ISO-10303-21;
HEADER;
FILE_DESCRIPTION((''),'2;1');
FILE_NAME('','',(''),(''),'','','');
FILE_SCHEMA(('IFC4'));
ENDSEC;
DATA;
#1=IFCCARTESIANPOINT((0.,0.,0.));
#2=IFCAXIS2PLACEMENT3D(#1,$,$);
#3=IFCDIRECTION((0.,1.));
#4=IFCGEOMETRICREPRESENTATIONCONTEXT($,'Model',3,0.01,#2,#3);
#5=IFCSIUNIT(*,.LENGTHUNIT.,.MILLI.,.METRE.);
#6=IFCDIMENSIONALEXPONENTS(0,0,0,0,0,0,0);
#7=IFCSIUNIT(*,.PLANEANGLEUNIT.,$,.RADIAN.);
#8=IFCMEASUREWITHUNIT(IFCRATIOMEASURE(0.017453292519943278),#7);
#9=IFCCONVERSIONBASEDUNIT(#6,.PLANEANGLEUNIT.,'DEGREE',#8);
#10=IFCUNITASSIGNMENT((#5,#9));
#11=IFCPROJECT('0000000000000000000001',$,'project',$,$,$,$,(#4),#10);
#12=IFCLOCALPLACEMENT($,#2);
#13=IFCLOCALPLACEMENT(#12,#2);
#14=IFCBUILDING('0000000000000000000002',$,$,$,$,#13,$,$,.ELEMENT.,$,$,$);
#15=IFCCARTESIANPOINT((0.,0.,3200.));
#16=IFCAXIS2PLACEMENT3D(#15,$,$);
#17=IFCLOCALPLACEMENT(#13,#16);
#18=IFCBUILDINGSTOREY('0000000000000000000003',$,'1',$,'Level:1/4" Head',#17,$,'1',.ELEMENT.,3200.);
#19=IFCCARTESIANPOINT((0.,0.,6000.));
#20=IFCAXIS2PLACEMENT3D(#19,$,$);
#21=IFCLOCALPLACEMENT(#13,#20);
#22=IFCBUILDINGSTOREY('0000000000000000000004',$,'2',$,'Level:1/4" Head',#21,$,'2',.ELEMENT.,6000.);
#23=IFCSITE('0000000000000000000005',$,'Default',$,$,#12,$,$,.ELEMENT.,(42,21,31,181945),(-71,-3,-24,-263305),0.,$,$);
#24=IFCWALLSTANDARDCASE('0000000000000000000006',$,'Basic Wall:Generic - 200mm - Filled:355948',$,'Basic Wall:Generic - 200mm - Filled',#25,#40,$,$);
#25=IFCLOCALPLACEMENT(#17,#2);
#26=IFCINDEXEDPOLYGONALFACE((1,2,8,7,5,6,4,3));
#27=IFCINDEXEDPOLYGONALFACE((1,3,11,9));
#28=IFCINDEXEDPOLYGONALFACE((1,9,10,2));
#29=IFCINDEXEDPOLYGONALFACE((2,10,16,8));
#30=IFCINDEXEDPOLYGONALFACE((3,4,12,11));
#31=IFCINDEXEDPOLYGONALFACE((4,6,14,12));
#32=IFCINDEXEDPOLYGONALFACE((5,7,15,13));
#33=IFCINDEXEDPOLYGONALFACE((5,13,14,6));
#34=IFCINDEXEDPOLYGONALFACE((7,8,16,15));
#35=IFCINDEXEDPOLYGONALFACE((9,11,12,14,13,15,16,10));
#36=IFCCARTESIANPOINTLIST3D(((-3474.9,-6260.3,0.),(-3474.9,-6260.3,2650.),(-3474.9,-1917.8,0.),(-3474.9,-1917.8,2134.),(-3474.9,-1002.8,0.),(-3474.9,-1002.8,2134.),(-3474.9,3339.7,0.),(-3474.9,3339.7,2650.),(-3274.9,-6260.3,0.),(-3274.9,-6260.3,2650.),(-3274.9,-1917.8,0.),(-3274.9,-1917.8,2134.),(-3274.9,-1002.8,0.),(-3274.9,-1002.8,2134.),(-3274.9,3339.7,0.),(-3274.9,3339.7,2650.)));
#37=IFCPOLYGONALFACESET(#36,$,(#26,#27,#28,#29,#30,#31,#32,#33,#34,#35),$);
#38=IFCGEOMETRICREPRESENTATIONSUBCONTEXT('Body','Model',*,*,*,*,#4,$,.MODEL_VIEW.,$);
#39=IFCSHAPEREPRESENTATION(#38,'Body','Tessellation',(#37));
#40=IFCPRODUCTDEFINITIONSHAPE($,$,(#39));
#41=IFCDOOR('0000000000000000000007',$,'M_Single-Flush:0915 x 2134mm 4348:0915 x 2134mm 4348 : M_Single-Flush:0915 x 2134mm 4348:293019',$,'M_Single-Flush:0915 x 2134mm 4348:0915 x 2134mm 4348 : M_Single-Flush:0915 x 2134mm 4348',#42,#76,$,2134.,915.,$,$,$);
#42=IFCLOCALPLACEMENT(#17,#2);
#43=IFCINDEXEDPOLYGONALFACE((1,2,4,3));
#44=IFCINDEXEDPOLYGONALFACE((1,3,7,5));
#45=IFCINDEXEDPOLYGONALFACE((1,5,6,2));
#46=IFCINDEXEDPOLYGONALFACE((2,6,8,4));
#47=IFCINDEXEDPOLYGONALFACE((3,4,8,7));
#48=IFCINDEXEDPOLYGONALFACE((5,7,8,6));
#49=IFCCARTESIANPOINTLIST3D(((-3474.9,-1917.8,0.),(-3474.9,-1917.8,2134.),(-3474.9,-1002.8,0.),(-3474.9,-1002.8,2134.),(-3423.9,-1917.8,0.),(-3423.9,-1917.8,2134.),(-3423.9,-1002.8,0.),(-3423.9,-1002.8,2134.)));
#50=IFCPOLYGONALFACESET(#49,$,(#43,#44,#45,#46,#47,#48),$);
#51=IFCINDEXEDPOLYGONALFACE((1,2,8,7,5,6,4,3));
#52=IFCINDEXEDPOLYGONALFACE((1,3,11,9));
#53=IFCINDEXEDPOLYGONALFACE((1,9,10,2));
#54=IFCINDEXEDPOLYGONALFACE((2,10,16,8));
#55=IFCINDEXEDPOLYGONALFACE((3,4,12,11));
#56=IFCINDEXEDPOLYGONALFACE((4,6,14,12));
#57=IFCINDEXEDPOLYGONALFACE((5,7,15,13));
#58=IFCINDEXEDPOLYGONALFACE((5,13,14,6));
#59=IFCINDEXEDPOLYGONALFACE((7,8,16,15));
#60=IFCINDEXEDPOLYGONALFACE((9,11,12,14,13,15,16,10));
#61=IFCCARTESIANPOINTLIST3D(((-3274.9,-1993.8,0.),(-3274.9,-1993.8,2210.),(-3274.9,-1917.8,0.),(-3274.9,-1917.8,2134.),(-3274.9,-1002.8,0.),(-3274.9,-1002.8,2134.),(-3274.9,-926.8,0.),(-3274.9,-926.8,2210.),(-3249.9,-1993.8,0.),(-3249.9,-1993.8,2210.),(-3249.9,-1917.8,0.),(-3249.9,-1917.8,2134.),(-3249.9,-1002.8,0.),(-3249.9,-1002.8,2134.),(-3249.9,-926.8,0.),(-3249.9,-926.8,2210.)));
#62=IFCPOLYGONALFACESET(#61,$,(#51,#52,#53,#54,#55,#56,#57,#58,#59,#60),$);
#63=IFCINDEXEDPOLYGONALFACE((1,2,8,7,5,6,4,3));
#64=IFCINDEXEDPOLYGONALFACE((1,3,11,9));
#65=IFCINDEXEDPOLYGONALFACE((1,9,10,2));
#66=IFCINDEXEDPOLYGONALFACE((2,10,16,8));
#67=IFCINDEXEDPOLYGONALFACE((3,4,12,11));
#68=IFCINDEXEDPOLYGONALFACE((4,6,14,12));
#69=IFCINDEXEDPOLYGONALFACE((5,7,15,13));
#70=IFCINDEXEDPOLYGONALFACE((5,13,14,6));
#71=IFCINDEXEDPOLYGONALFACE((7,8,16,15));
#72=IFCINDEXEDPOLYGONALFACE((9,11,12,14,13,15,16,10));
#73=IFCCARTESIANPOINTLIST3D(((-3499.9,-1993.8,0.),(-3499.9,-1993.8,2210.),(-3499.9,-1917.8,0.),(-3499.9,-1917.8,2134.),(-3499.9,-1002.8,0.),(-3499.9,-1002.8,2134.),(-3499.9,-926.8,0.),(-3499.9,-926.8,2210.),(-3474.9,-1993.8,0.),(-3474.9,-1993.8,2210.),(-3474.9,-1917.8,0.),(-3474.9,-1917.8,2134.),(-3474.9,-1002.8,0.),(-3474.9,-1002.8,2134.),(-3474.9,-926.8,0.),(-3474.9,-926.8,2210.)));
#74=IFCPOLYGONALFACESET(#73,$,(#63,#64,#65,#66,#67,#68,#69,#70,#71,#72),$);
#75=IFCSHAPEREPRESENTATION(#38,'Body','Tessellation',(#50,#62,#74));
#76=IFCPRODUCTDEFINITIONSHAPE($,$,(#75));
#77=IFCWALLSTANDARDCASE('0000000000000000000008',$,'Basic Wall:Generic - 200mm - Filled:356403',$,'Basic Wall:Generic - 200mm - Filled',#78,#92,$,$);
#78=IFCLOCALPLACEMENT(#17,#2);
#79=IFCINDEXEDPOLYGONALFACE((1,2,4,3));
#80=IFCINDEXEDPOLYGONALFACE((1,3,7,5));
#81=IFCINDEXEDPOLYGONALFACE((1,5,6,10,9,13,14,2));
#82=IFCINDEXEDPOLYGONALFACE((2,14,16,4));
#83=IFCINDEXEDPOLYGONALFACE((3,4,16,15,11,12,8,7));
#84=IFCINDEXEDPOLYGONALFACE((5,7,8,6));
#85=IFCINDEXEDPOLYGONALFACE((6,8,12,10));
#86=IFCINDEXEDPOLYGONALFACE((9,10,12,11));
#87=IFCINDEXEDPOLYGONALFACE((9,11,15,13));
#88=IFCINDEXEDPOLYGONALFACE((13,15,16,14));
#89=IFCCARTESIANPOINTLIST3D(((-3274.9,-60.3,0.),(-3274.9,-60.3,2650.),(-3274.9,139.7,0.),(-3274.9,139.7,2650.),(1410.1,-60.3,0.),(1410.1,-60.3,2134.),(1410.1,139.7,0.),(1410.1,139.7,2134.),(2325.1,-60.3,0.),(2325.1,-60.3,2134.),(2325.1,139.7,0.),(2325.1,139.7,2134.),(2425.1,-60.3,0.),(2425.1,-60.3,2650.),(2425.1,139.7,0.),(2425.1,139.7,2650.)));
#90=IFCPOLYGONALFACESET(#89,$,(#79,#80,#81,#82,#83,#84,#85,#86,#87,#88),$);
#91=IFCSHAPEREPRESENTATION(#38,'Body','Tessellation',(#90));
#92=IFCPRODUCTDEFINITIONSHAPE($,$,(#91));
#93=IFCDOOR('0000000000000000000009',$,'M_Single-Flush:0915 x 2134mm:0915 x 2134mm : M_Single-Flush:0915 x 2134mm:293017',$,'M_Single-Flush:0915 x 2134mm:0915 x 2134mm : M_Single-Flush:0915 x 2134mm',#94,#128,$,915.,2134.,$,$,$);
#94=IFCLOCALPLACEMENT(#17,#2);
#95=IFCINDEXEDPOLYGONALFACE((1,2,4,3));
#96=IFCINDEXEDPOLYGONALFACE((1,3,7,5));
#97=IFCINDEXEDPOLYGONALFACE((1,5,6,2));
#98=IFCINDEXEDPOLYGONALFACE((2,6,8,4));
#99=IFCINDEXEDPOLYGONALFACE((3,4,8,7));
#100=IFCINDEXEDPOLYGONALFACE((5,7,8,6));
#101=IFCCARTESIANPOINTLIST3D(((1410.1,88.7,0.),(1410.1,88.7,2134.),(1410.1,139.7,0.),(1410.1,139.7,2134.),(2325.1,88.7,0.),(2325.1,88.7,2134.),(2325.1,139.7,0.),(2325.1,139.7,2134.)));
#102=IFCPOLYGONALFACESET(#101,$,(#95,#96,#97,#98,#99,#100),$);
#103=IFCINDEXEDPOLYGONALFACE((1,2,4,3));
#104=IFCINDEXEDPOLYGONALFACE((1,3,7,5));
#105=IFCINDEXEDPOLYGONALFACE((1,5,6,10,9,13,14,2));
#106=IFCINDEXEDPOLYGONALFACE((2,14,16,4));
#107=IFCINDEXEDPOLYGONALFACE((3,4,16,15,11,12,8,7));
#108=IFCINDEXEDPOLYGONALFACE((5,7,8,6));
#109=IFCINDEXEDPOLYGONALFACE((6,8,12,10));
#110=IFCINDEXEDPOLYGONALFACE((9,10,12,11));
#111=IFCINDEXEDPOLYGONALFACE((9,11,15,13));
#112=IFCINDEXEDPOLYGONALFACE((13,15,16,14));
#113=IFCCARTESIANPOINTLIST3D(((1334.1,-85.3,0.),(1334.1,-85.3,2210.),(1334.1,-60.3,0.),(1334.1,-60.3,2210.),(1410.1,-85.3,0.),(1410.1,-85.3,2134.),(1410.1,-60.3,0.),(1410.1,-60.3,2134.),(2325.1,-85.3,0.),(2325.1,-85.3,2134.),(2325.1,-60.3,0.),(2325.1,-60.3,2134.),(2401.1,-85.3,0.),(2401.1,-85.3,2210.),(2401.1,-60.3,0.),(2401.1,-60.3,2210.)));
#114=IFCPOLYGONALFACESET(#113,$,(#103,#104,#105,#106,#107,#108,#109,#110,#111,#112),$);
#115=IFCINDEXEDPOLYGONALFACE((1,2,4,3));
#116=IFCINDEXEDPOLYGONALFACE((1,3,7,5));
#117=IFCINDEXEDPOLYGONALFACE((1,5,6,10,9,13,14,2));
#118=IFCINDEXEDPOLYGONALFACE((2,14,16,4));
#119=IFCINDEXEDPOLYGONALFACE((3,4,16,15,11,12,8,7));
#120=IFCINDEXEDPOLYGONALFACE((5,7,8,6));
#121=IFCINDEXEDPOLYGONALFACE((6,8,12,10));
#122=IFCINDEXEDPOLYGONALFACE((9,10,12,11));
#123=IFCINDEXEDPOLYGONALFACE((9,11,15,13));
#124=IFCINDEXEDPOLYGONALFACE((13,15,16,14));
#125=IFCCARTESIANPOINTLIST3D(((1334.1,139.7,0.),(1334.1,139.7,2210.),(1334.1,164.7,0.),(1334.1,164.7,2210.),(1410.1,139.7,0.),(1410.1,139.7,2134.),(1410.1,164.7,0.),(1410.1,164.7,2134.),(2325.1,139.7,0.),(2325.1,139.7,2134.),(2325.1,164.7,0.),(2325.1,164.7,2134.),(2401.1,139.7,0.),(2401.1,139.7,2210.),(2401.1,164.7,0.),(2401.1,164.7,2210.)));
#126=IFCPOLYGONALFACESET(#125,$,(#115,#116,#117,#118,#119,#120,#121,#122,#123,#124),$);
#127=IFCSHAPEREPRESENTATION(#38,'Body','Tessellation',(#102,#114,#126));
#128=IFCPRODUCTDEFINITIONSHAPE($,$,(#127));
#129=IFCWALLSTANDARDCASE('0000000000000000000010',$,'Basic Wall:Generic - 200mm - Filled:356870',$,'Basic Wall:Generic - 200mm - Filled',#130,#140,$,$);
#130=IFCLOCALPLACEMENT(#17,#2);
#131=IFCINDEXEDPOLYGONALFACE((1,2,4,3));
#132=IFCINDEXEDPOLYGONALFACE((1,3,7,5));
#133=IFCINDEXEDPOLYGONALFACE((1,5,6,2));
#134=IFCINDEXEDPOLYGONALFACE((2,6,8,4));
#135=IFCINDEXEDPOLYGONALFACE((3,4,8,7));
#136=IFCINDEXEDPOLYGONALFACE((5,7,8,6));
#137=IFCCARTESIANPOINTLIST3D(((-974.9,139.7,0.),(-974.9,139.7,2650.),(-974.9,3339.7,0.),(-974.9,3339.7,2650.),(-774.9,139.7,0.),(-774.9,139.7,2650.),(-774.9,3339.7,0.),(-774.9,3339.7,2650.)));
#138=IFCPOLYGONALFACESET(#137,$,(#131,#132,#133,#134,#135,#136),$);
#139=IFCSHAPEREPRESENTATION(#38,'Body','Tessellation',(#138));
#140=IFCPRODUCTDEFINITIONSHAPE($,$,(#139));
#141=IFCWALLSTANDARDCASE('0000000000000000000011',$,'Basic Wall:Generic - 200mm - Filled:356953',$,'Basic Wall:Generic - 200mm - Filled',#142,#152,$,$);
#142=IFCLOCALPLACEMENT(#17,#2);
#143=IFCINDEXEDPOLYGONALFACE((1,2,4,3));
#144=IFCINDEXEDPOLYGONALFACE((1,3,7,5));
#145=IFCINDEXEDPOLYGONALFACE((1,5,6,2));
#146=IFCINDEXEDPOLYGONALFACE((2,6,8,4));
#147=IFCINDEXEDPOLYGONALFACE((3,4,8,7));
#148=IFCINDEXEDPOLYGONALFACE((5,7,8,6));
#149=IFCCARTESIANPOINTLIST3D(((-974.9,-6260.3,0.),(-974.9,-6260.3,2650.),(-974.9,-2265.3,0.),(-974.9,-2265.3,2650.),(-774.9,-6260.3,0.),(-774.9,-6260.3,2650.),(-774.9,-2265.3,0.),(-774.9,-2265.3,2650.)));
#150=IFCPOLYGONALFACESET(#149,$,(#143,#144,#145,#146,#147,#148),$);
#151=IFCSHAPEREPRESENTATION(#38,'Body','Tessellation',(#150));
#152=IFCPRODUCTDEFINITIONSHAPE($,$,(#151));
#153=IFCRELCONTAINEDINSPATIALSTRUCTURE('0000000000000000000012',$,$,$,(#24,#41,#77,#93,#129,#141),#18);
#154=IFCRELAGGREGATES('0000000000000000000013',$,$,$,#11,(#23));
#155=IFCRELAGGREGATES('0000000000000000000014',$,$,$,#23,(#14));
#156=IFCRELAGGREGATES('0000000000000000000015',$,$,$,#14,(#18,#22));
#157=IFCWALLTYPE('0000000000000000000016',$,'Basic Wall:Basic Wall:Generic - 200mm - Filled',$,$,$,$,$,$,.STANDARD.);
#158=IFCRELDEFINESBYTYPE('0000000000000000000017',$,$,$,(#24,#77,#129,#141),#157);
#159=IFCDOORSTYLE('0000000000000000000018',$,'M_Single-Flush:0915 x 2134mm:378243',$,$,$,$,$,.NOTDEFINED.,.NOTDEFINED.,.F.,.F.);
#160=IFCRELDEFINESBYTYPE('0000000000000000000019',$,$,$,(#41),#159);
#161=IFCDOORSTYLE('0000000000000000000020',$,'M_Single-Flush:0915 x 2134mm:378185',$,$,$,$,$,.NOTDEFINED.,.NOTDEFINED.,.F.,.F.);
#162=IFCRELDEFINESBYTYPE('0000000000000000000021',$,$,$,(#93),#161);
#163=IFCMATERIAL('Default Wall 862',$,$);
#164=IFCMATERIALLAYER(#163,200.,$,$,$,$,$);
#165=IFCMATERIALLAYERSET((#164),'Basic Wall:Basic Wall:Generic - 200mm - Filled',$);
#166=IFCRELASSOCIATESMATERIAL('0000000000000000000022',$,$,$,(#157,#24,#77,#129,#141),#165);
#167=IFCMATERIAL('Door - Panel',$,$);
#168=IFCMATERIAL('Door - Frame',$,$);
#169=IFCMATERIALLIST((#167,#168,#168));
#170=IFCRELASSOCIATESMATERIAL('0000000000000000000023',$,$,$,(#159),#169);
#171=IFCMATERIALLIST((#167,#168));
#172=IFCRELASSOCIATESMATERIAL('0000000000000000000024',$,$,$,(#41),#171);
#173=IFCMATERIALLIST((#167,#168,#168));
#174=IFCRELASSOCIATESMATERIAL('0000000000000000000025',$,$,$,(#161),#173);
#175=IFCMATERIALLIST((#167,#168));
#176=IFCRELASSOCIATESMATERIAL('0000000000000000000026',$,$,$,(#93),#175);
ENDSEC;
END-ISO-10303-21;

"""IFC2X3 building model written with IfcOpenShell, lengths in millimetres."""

from ifc_helpers import new_model, entity, si_unit, converted_unit, direction, frame, frame_2d, origin, origin_2d_with_axis, place, context, subcontext, project, spatial, polyline, rectangle, outline, extrude, source, transform, mapped, material, material_list, layer, layer_set, layer_usage, type_object, type_shapes, element, fill, save


model = new_model("IFC2X3")

# Units and contexts
model_context = context("Model", 3, precision=0.01, world=origin(), true_north=direction((0.0, 1.0)))
body_context = subcontext(model_context, "Body", "Model", "MODEL_VIEW")
ifc_project = project(units=[si_unit("LENGTHUNIT", "METRE", prefix="MILLI"), converted_unit("PLANEANGLEUNIT", "DEGREE", entity("IfcRatioMeasure", 0.017453292519943278), si_unit("PLANEANGLEUNIT", "RADIAN"), dimensions=[0, 0, 0, 0, 0, 0, 0])], contexts=[model_context])

# Site, building, storey
site_placement = place(None, origin())
site = spatial("IfcSite", under=ifc_project, at=site_placement, Name="Default", CompositionType="ELEMENT", RefLatitude=(42, 21, 31, 181945), RefLongitude=(-71, -3, -24, -263305), RefElevation=0.0)
building_placement = place(site_placement, origin())
building = spatial("IfcBuilding", under=site, at=building_placement, CompositionType="ELEMENT")
storey_1_placement = place(building_placement, frame((0.0, 0.0, 3200.0)))
storey_1 = spatial("IfcBuildingStorey", under=building, at=storey_1_placement, Name="1", ObjectType="Level:1/4\" Head", LongName="1", CompositionType="ELEMENT", Elevation=3200.0)

# Shared definitions
ifc_material_1 = material(Name="Default Wall 862")

# Shared definitions
storey_2_placement = place(building_placement, frame((0.0, 0.0, 6000.0)))
storey_2 = spatial("IfcBuildingStorey", under=building, at=storey_2_placement, Name="2", ObjectType="Level:1/4\" Head", LongName="2", CompositionType="ELEMENT", Elevation=6000.0)

# Walls, openings, doors
ifc_layer_1 = layer(ifc_material_1, 200.0)
ifc_layer_set_1 = layer_set([ifc_layer_1], Name="Basic Wall:Basic Wall:Generic - 200mm - Filled")
ifc_layer_usage_1 = layer_usage(ifc_layer_set_1, "AXIS2", "NEGATIVE", 100.0)
wall_type_1 = type_object("IfcWallType", Name="Basic Wall:Basic Wall:Generic - 200mm - Filled", PredefinedType="STANDARD", material=ifc_layer_set_1)
wall_1_placement = place(storey_1_placement, frame((-3374.9, 3339.7, 0.0), z_axis=(0.0, 0.0, 1.0), x_axis=(0.0, -1.0, 0.0)))
wall_1 = element("IfcWallStandardCase", 1, at=wall_1_placement, inside=storey_1, type_object=wall_type_1, material=ifc_layer_usage_1, Name="Basic Wall:Generic - 200mm - Filled:355948", ObjectType="Basic Wall:Generic - 200mm - Filled", context=body_context, shape_type="SweptSolid", body=[
    extrude(rectangle(XDim=9600.0, YDim=200.0, at=frame_2d((4800.0, 0.0), x_axis=(1.0, 0.0))), origin(), (0.0, 0.0, 1.0), 2650.0),
])
opening_1_placement = place(wall_1_placement, frame((3339.7, 3374.9, 0.0), z_axis=(0.0, 0.0, 1.0), x_axis=(0.0, 1.0, 0.0)))
opening_1 = element("IfcOpeningElement", 2, at=opening_1_placement, cuts=wall_1, ObjectType="Opening", context=body_context, shape_type="SweptSolid", body=[
    extrude(rectangle(XDim=2134.0, YDim=915.0, at=frame_2d((0.0, 0.0), x_axis=(0.0, 1.0))), frame((-3476.9, -1460.3, 1067.0), z_axis=(1.0, 0.0, 0.0), x_axis=(0.0, -1.0, 0.0)), (0.0, 0.0, 1.0), 204.0),
])
ifc_material_2 = material(Name="Door - Panel")
ifc_material_3 = material(Name="Door - Frame")
ifc_material_list_1 = material_list([ifc_material_2, ifc_material_3])
ifc_material_list_2 = material_list([ifc_material_2, ifc_material_3, ifc_material_3])
door_style_1 = type_object("IfcDoorStyle", Name="M_Single-Flush:0915 x 2134mm:378243", ConstructionType="NOTDEFINED", OperationType="NOTDEFINED", ParameterTakesPrecedence=False, Sizeable=False, material=ifc_material_list_2)
shared_shape_1 = source(origin(), body_context, "Body", "SweptSolid", [
    extrude(rectangle(XDim=915.0, YDim=51.0, at=origin_2d_with_axis()), frame((457.5, 176.5, 0.0), z_axis=(0.0, 0.0, 1.0), x_axis=(-1.0, 0.0, 0.0)), (0.0, 0.0, 1.0), 2134.0),
    extrude(outline(polyline([(-533.5, -1086.0), (-457.5, -1086.0), (-457.5, 1048.0), (457.5, 1048.0), (457.5, -1086.0), (533.5, -1086.0), (533.5, 1124.0), (-533.5, 1124.0), (-533.5, -1086.0)])), frame((457.5, -23.0, 1086.0), z_axis=(0.0, 1.0, 0.0), x_axis=(-1.0, 0.0, 0.0)), (0.0, 0.0, 1.0), 25.0),
    extrude(outline(polyline([(-1124.0, -533.5), (1086.0, -533.5), (1086.0, -457.5), (-1048.0, -457.5), (-1048.0, 457.5), (1086.0, 457.5), (1086.0, 533.5), (-1124.0, 533.5), (-1124.0, -533.5)])), frame((457.5, 202.0, 1086.0), z_axis=(0.0, 1.0, 0.0), x_axis=(0.0, 0.0, -1.0)), (0.0, 0.0, 1.0), 25.0),
])
type_shapes(door_style_1, [shared_shape_1])
door_1_placement = place(opening_1_placement, frame((-3272.9, -1917.8, 0.0), z_axis=(0.0, 0.0, 1.0), x_axis=(0.0, 1.0, 0.0)))
door_1 = element("IfcDoor", 3, at=door_1_placement, inside=storey_1, type_object=door_style_1, material=ifc_material_list_1, Name="M_Single-Flush:0915 x 2134mm 4348:0915 x 2134mm 4348 : M_Single-Flush:0915 x 2134mm 4348:293019", ObjectType="M_Single-Flush:0915 x 2134mm 4348:0915 x 2134mm 4348 : M_Single-Flush:0915 x 2134mm 4348", OverallHeight=2134.0, OverallWidth=915.0, context=body_context, shape_type="MappedRepresentation", body=[
    mapped(shared_shape_1, transform((0.0, 0.0, 0.0), scale=1.0)),
])
fill(opening_1, door_1)
ifc_layer_usage_2 = layer_usage(ifc_layer_set_1, "AXIS2", "NEGATIVE", 100.0)
wall_2_placement = place(storey_1_placement, frame((-3274.9, 39.7, 0.0)))
wall_2 = element("IfcWallStandardCase", 4, at=wall_2_placement, inside=storey_1, type_object=wall_type_1, material=ifc_layer_usage_2, Name="Basic Wall:Generic - 200mm - Filled:356403", ObjectType="Basic Wall:Generic - 200mm - Filled", context=body_context, shape_type="SweptSolid", body=[
    extrude(rectangle(XDim=5700.0, YDim=200.0, at=frame_2d((2850.0, 0.0), x_axis=(-1.0, 0.0))), origin(), (0.0, 0.0, 1.0), 2650.0),
])
opening_2_placement = place(wall_2_placement, frame((3274.9, -39.7, 0.0)))
opening_2 = element("IfcOpeningElement", 5, at=opening_2_placement, cuts=wall_2, ObjectType="Opening", context=body_context, shape_type="SweptSolid", body=[
    extrude(rectangle(XDim=2134.0, YDim=915.0, at=frame_2d((0.0, 0.0), x_axis=(1.0, 0.0))), frame((1867.6, -62.3, 1067.0), z_axis=(0.0, 1.0, 0.0), x_axis=(0.0, 0.0, 1.0)), (0.0, 0.0, 1.0), 204.0),
])
ifc_material_list_3 = material_list([ifc_material_2, ifc_material_3])
ifc_material_list_4 = material_list([ifc_material_2, ifc_material_3, ifc_material_3])
door_style_2 = type_object("IfcDoorStyle", Name="M_Single-Flush:0915 x 2134mm:378185", ConstructionType="NOTDEFINED", OperationType="NOTDEFINED", ParameterTakesPrecedence=False, Sizeable=False, material=ifc_material_list_4)
shared_shape_2 = source(origin(), body_context, "Body", "SweptSolid", [
    extrude(rectangle(XDim=51.0, YDim=915.0, at=origin_2d_with_axis()), frame((457.5, -27.5, 0.0), z_axis=(0.0, 0.0, 1.0), x_axis=(0.0, 1.0, 0.0)), (0.0, 0.0, 1.0), 2134.0),
    extrude(outline(polyline([(-1086.0, -533.5), (1124.0, -533.5), (1124.0, 533.5), (-1086.0, 533.5), (-1086.0, 457.5), (1048.0, 457.5), (1048.0, -457.5), (-1086.0, -457.5), (-1086.0, -533.5)])), frame((457.5, -227.0, 1086.0), z_axis=(0.0, 1.0, 0.0), x_axis=(0.0, 0.0, 1.0)), (0.0, 0.0, 1.0), 25.0),
    extrude(outline(polyline([(-533.5, -1124.0), (533.5, -1124.0), (533.5, 1086.0), (457.5, 1086.0), (457.5, -1048.0), (-457.5, -1048.0), (-457.5, 1086.0), (-533.5, 1086.0), (-533.5, -1124.0)])), frame((457.5, -2.0, 1086.0), z_axis=(0.0, 1.0, 0.0), x_axis=(1.0, 0.0, 0.0)), (0.0, 0.0, 1.0), 25.0),
])
type_shapes(door_style_2, [shared_shape_2])
door_2_placement = place(opening_2_placement, frame((1410.1, 141.7, 0.0)))
door_2 = element("IfcDoor", 6, at=door_2_placement, inside=storey_1, type_object=door_style_2, material=ifc_material_list_3, Name="M_Single-Flush:0915 x 2134mm:0915 x 2134mm : M_Single-Flush:0915 x 2134mm:293017", ObjectType="M_Single-Flush:0915 x 2134mm:0915 x 2134mm : M_Single-Flush:0915 x 2134mm", OverallHeight=915.0, OverallWidth=2134.0, context=body_context, shape_type="MappedRepresentation", body=[
    mapped(shared_shape_2, transform((0.0, 0.0, 0.0), scale=1.0)),
])
fill(opening_2, door_2)

# Walls
ifc_layer_usage_3 = layer_usage(ifc_layer_set_1, "AXIS2", "NEGATIVE", 100.0)
wall_3_placement = place(storey_1_placement, frame((-874.9, 3339.7, 0.0), z_axis=(0.0, 0.0, 1.0), x_axis=(0.0, -1.0, 0.0)))
element("IfcWallStandardCase", 7, at=wall_3_placement, inside=storey_1, type_object=wall_type_1, material=ifc_layer_usage_3, Name="Basic Wall:Generic - 200mm - Filled:356870", ObjectType="Basic Wall:Generic - 200mm - Filled", context=body_context, shape_type="SweptSolid", body=[
    extrude(rectangle(XDim=3200.0, YDim=200.0, at=frame_2d((1600.0, 0.0), x_axis=(-1.0, 0.0))), origin(), (0.0, 0.0, 1.0), 2650.0),
])
ifc_layer_usage_4 = layer_usage(ifc_layer_set_1, "AXIS2", "NEGATIVE", 100.0)
wall_4_placement = place(storey_1_placement, frame((-874.9, -2265.3, 0.0), z_axis=(0.0, 0.0, 1.0), x_axis=(0.0, -1.0, 0.0)))
element("IfcWallStandardCase", 8, at=wall_4_placement, inside=storey_1, type_object=wall_type_1, material=ifc_layer_usage_4, Name="Basic Wall:Generic - 200mm - Filled:356953", ObjectType="Basic Wall:Generic - 200mm - Filled", context=body_context, shape_type="SweptSolid", body=[
    extrude(rectangle(XDim=3995.0, YDim=200.0, at=frame_2d((1997.5, 0.0), x_axis=(-1.0, 0.0))), origin(), (0.0, 0.0, 1.0), 2650.0),
])

save(model, "model.ifc")
